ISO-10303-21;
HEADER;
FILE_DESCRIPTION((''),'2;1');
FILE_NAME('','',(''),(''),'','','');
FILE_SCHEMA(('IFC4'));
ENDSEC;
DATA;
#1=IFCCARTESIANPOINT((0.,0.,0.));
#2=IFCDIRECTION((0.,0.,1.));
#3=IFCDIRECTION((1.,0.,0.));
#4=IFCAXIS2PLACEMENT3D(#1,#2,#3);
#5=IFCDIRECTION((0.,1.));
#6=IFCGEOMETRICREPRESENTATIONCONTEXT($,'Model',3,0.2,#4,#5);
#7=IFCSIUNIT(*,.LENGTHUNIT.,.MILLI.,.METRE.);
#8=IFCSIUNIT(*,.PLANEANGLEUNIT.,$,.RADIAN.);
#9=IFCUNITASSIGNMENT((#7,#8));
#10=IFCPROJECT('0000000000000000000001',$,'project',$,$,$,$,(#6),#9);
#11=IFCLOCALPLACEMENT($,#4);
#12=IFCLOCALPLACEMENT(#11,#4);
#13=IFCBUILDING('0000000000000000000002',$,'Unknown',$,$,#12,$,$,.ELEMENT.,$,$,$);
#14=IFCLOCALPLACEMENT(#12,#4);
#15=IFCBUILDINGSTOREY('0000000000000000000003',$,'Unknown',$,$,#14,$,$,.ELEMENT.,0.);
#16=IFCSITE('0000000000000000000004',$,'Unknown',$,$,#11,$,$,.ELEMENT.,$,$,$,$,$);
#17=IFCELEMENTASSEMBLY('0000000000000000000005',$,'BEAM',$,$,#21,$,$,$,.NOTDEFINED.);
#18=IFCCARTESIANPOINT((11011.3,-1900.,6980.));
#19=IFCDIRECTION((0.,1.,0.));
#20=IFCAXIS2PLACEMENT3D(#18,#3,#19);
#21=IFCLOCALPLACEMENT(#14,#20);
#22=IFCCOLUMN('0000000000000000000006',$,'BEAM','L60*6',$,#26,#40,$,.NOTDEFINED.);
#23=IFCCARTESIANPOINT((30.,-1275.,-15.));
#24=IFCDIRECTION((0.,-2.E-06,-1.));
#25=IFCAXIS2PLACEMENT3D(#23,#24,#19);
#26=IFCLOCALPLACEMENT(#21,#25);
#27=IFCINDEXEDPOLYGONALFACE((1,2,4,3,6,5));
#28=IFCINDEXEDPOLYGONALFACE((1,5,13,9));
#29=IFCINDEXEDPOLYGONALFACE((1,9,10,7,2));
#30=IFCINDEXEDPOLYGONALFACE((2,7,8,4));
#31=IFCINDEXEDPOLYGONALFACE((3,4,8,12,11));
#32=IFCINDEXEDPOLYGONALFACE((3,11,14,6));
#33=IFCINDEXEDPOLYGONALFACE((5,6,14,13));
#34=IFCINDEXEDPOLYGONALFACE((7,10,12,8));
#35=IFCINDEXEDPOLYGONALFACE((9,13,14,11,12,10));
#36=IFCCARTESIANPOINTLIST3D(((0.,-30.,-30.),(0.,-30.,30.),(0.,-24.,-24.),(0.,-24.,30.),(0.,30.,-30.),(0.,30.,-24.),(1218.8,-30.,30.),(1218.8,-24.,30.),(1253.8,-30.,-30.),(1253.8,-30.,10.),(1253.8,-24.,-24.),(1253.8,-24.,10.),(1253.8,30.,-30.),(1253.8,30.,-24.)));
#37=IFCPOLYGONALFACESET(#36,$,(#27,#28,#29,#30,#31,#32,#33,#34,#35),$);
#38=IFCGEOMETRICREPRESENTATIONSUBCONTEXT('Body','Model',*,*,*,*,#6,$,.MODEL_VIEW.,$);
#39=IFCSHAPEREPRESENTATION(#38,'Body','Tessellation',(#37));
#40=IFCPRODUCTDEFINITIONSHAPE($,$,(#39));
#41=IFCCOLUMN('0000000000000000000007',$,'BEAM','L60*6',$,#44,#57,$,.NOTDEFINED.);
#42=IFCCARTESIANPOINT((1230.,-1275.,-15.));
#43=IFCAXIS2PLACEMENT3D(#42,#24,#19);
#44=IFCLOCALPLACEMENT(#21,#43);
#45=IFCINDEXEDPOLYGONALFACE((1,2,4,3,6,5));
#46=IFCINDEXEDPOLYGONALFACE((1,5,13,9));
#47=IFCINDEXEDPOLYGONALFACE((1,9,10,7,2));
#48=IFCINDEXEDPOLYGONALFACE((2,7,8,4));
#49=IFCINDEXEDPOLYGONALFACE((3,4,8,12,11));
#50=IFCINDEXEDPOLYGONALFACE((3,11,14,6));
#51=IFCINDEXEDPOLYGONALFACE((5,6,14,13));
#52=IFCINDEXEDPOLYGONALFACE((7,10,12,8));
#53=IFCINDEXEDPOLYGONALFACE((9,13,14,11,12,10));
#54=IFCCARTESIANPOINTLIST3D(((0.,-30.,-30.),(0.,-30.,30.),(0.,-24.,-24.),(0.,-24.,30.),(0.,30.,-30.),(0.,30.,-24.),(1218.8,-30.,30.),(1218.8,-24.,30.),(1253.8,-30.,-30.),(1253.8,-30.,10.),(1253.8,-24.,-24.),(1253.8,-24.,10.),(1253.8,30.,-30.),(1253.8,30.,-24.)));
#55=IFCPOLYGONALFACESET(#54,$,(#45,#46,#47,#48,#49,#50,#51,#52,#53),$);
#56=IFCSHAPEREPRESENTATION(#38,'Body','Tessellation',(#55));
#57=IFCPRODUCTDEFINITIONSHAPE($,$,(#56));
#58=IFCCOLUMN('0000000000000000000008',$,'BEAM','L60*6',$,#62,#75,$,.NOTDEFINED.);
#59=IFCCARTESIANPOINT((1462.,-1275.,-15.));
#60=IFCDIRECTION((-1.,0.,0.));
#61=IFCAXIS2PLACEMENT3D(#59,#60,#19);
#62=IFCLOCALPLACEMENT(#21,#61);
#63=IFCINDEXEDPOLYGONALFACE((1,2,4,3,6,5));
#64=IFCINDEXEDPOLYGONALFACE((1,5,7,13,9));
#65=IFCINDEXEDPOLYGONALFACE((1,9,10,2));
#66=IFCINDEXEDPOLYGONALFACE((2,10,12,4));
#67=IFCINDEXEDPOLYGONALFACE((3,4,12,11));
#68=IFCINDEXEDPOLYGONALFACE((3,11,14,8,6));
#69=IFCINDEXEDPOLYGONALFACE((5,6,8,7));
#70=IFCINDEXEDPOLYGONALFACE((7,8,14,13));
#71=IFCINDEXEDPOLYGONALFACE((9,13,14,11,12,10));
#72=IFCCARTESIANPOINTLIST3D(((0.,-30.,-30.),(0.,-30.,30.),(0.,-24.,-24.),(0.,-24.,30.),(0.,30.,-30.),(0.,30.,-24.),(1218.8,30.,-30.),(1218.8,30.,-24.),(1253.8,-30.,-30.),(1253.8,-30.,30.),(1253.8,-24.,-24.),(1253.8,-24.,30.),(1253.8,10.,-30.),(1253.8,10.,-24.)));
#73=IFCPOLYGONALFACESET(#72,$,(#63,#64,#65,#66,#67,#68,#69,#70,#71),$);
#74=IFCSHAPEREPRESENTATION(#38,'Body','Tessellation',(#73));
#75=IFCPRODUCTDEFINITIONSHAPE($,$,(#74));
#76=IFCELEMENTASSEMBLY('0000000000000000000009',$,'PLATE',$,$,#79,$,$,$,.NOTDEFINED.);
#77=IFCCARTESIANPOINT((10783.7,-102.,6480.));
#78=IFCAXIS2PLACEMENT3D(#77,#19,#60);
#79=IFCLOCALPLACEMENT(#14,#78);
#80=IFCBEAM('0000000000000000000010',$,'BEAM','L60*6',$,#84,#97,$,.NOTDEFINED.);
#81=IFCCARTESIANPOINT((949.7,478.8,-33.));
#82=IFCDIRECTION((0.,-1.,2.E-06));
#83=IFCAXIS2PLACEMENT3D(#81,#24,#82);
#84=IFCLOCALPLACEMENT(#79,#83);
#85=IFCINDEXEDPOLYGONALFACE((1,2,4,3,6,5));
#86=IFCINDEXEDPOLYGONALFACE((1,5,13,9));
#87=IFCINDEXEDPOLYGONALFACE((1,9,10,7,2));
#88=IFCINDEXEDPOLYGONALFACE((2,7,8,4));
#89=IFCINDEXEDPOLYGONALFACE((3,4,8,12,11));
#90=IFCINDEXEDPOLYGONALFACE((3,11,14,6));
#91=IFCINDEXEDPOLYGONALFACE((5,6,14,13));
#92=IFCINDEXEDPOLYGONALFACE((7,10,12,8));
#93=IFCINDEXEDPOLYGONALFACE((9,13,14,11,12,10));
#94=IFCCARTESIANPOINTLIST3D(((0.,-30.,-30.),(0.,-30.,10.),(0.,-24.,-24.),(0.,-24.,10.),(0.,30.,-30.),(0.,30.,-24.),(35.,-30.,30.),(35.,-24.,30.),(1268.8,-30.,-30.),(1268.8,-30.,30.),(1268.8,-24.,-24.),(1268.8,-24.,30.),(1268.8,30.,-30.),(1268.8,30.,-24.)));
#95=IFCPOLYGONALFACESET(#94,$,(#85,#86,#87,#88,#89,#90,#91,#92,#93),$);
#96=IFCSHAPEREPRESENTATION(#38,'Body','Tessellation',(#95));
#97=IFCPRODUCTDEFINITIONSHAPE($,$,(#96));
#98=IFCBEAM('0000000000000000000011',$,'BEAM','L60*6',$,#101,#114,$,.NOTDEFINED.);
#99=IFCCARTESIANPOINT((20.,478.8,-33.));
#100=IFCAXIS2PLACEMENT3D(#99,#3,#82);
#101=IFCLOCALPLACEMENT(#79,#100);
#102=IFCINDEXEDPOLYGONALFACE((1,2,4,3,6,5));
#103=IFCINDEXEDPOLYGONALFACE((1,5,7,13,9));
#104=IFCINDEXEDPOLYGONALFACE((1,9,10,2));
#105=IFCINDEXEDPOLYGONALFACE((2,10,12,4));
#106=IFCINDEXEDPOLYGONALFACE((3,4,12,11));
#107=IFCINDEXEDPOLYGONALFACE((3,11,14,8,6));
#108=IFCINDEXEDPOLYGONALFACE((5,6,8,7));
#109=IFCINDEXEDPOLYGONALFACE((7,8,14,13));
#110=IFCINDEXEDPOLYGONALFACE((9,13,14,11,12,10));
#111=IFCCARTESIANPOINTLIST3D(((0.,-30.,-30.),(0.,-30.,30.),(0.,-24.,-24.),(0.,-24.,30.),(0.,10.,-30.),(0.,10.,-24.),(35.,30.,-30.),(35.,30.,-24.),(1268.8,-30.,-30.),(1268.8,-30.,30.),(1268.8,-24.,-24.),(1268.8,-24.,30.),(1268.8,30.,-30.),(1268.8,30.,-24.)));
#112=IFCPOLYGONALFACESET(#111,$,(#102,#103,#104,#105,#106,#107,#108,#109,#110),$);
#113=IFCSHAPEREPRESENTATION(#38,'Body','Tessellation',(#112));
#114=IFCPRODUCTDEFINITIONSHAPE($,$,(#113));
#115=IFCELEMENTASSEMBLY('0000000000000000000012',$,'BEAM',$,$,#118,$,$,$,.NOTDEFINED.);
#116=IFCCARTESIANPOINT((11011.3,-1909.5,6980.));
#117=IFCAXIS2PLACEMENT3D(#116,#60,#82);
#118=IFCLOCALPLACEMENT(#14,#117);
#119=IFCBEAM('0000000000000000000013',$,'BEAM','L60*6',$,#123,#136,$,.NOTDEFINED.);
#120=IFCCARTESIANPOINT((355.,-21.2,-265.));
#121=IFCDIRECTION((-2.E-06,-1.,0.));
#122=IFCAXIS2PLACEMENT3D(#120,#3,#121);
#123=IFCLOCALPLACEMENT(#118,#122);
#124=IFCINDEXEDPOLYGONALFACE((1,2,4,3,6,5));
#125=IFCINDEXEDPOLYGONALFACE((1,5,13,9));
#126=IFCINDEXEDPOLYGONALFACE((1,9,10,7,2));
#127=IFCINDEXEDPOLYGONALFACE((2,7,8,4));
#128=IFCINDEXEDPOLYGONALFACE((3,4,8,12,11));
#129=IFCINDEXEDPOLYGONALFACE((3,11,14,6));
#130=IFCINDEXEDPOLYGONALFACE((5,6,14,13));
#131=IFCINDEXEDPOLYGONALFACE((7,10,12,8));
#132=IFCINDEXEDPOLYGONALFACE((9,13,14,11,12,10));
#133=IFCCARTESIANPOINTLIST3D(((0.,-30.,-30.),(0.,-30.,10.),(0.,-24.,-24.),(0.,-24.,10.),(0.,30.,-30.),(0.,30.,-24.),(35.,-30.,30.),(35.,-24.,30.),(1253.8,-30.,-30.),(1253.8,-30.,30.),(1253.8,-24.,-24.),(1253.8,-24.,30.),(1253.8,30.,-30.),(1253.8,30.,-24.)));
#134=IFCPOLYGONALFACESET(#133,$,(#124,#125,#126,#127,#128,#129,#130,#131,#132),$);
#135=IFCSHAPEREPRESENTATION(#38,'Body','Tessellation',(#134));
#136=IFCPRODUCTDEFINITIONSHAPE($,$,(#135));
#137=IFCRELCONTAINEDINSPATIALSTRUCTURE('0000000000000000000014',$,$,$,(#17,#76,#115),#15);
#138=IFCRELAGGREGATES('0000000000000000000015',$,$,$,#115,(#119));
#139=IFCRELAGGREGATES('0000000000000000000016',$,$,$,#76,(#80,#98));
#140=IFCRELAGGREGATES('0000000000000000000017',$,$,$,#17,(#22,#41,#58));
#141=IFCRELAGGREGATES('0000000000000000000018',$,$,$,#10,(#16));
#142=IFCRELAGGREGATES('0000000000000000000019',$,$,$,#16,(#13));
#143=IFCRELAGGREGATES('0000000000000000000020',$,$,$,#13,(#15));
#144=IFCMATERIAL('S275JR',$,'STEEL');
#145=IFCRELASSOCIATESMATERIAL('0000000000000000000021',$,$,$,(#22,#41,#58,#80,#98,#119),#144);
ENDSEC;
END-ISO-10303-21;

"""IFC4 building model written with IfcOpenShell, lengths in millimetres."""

from ifc_helpers import new_model, si_unit, direction, frame, origin_with_axes, place, context, subcontext, project, spatial, line, indexed_curve, outline, extrude, material, element, aggregate, save


model = new_model("IFC4")

# Units and contexts
model_context = context("Model", 3, precision=0.2, world=origin_with_axes(), true_north=direction((0.0, 1.0)))
body_context = subcontext(model_context, "Body", "Model", "MODEL_VIEW")
ifc_project = project(units=[si_unit("LENGTHUNIT", "METRE", prefix="MILLI"), si_unit("PLANEANGLEUNIT", "RADIAN")], contexts=[model_context])

# Site, building, storey
site_placement = place(None, origin_with_axes())
site = spatial("IfcSite", under=ifc_project, at=site_placement, Name="Unknown", CompositionType="ELEMENT")
building_placement = place(site_placement, origin_with_axes())
building = spatial("IfcBuilding", under=site, at=building_placement, Name="Unknown", CompositionType="ELEMENT")
storey_placement = place(building_placement, origin_with_axes())
storey = spatial("IfcBuildingStorey", under=building, at=storey_placement, Name="Unknown", CompositionType="ELEMENT", Elevation=0.0)

# Shared definitions
ifc_material_1 = material(Name="S275JR", Category="STEEL")

# Element assembly, columns, voiding features
assembly_1_placement = place(storey_placement, frame((11011.3, -1900.0, 6980.0), z_axis=(1.0, 0.0, 0.0), x_axis=(0.0, 1.0, 0.0)))
assembly_1 = element("IfcElementAssembly", 1, at=assembly_1_placement, inside=storey, Name="BEAM", PredefinedType="NOTDEFINED")
column_1_placement = place(assembly_1_placement, frame((30.0, -1275.0, -15.0), z_axis=(0.0, -0.000002, -1.0), x_axis=(0.0, 1.0, 0.0)))
column_1 = element("IfcColumn", 2, at=column_1_placement, material=ifc_material_1, Name="BEAM", Description="L60*6", PredefinedType="NOTDEFINED", context=body_context, shape_type="SolidModel", body=[
    extrude(outline(indexed_curve([(-30.0, -30.0), (30.0, -30.0), (30.0, -24.0), (-24.0, -24.0), (-24.0, 30.0), (-30.0, 30.0)], segments=[line(1, 2, 3, 4, 5, 6, 1)])), frame((0.0, 0.0, 0.0), z_axis=(-1.0, 0.0, 0.0), x_axis=(0.0, 0.0, 1.0)), (0.0, -0.000002, -1.0), 1253.8),
])
voiding_feature_1_placement = place(column_1_placement, frame((1253.8, 0.0, 10.0), z_axis=(0.0, -1.0, 0.000002), x_axis=(0.0, 0.0, 1.0)))
element("IfcVoidingFeature", 3, at=voiding_feature_1_placement, cuts=column_1, Name="CUTPART", PredefinedType="HOLE", context=body_context, shape_type="SolidModel", body=[
    extrude(outline(indexed_curve([(0.0, 0.0), (20.0, 0.0), (20.0, 35.0)], segments=[line(1, 2, 3, 1)])), frame((0.0, 0.0, 33.0), z_axis=(0.0, 0.0, 1.0), x_axis=(1.0, 0.0, 0.0)), (0.0, -0.000002, -1.0), 66.0),
])
column_2_placement = place(assembly_1_placement, frame((1230.0, -1275.0, -15.0), z_axis=(0.0, -0.000002, -1.0), x_axis=(0.0, 1.0, 0.0)))
column_2 = element("IfcColumn", 4, at=column_2_placement, material=ifc_material_1, Name="BEAM", Description="L60*6", PredefinedType="NOTDEFINED", context=body_context, shape_type="SolidModel", body=[
    extrude(outline(indexed_curve([(-30.0, -30.0), (30.0, -30.0), (30.0, -24.0), (-24.0, -24.0), (-24.0, 30.0), (-30.0, 30.0)], segments=[line(1, 2, 3, 4, 5, 6, 1)])), frame((0.0, 0.0, 0.0), z_axis=(-1.0, 0.0, 0.0), x_axis=(0.0, 0.0, 1.0)), (0.0, -0.000002, -1.0), 1253.8),
])
voiding_feature_2_placement = place(column_2_placement, frame((1253.8, 0.0, 10.0), z_axis=(0.0, -1.0, 0.000002), x_axis=(0.0, 0.0, 1.0)))
element("IfcVoidingFeature", 5, at=voiding_feature_2_placement, cuts=column_2, Name="CUTPART", PredefinedType="HOLE", context=body_context, shape_type="SolidModel", body=[
    extrude(outline(indexed_curve([(0.0, 0.0), (20.0, 0.0), (20.0, 35.0)], segments=[line(1, 2, 3, 1)])), frame((0.0, 0.0, 33.0), z_axis=(0.0, 0.0, 1.0), x_axis=(1.0, 0.0, 0.0)), (0.0, -0.000002, -1.0), 66.0),
])
column_3_placement = place(assembly_1_placement, frame((1462.0, -1275.0, -15.0), z_axis=(-1.0, 0.0, 0.0), x_axis=(0.0, 1.0, 0.0)))
column_3 = element("IfcColumn", 6, at=column_3_placement, material=ifc_material_1, Name="BEAM", Description="L60*6", PredefinedType="NOTDEFINED", context=body_context, shape_type="SolidModel", body=[
    extrude(outline(indexed_curve([(-30.0, -30.0), (30.0, -30.0), (30.0, -24.0), (-24.0, -24.0), (-24.0, 30.0), (-30.0, 30.0)], segments=[line(1, 2, 3, 4, 5, 6, 1)])), frame((0.0, 0.0, 0.0), z_axis=(-1.0, 0.0, 0.0), x_axis=(0.0, 0.0, 1.0)), (0.0, -0.000002, -1.0), 1253.8),
])
voiding_feature_3_placement = place(column_3_placement, frame((1253.8, 10.0, 0.0), z_axis=(0.0, 0.0, 1.0), x_axis=(0.0, 1.0, 0.0)))
element("IfcVoidingFeature", 7, at=voiding_feature_3_placement, cuts=column_3, Name="CUTPART", PredefinedType="HOLE", context=body_context, shape_type="SolidModel", body=[
    extrude(outline(indexed_curve([(0.0, 0.0), (20.0, 0.0), (20.0, 35.0)], segments=[line(1, 2, 3, 1)])), frame((0.0, 0.0, 33.0), z_axis=(0.0, 0.0, 1.0), x_axis=(1.0, 0.0, 0.0)), (0.0, -0.000002, -1.0), 66.0),
])

# Element assembly, beams, voiding features
assembly_2_placement = place(storey_placement, frame((10783.7, -102.0, 6480.0), z_axis=(0.0, 1.0, 0.0), x_axis=(-1.0, 0.0, 0.0)))
assembly_2 = element("IfcElementAssembly", 8, at=assembly_2_placement, inside=storey, Name="PLATE", PredefinedType="NOTDEFINED")
beam_1_placement = place(assembly_2_placement, frame((949.7, 478.8, -33.0), z_axis=(0.0, -0.000002, -1.0), x_axis=(0.0, -1.0, 0.000002)))
beam_1 = element("IfcBeam", 9, at=beam_1_placement, material=ifc_material_1, Name="BEAM", Description="L60*6", PredefinedType="NOTDEFINED", context=body_context, shape_type="SolidModel", body=[
    extrude(outline(indexed_curve([(-30.0, -30.0), (30.0, -30.0), (30.0, -24.0), (-24.0, -24.0), (-24.0, 30.0), (-30.0, 30.0)], segments=[line(1, 2, 3, 4, 5, 6, 1)])), frame((0.0, 0.0, 0.0), z_axis=(-1.0, 0.0, 0.0), x_axis=(0.0, 0.0, 1.0)), (0.0, -0.000002, -1.0), 1268.8),
])
voiding_feature_4_placement = place(beam_1_placement, frame((0.0, 0.0, 10.0), z_axis=(0.0, 1.0, 0.0), x_axis=(0.0, 0.0, 1.0)))
element("IfcVoidingFeature", 10, at=voiding_feature_4_placement, cuts=beam_1, Name="CUTPART", PredefinedType="HOLE", context=body_context, shape_type="SolidModel", body=[
    extrude(outline(indexed_curve([(0.0, 0.0), (20.0, 0.0), (20.0, 35.0)], segments=[line(1, 2, 3, 1)])), frame((0.0, 0.0, 33.0), z_axis=(0.0, 0.0, 1.0), x_axis=(1.0, 0.0, 0.0)), (0.0, -0.000002, -1.0), 66.0),
])
beam_2_placement = place(assembly_2_placement, frame((20.0, 478.8, -33.0), z_axis=(1.0, 0.0, 0.0), x_axis=(0.0, -1.0, 0.000002)))
beam_2 = element("IfcBeam", 11, at=beam_2_placement, material=ifc_material_1, Name="BEAM", Description="L60*6", PredefinedType="NOTDEFINED", context=body_context, shape_type="SolidModel", body=[
    extrude(outline(indexed_curve([(-30.0, -30.0), (30.0, -30.0), (30.0, -24.0), (-24.0, -24.0), (-24.0, 30.0), (-30.0, 30.0)], segments=[line(1, 2, 3, 4, 5, 6, 1)])), frame((0.0, 0.0, 0.0), z_axis=(-1.0, 0.0, 0.0), x_axis=(0.0, 0.0, 1.0)), (0.0, -0.000002, -1.0), 1268.8),
])
voiding_feature_5_placement = place(beam_2_placement, frame((0.0, 10.0, 0.0), z_axis=(0.0, -0.000002, -1.0), x_axis=(0.0, 1.0, 0.0)))
element("IfcVoidingFeature", 12, at=voiding_feature_5_placement, cuts=beam_2, Name="CUTPART", PredefinedType="HOLE", context=body_context, shape_type="SolidModel", body=[
    extrude(outline(indexed_curve([(0.0, 0.0), (20.0, 0.0), (20.0, 35.0)], segments=[line(1, 2, 3, 1)])), frame((0.0, 0.0, 33.0), z_axis=(0.0, 0.0, 1.0), x_axis=(1.0, 0.0, 0.0)), (0.0, -0.000002, -1.0), 66.0),
])

# Element assembly, beam, voiding feature
assembly_3_placement = place(storey_placement, frame((11011.3, -1909.5, 6980.0), z_axis=(-1.0, 0.0, 0.0), x_axis=(0.0, -1.0, 0.000002)))
assembly_3 = element("IfcElementAssembly", 13, at=assembly_3_placement, inside=storey, Name="BEAM", PredefinedType="NOTDEFINED")
beam_3_placement = place(assembly_3_placement, frame((355.0, -21.2, -265.0), z_axis=(1.0, 0.0, 0.0), x_axis=(-0.000002, -1.0, 0.0)))
beam_3 = element("IfcBeam", 14, at=beam_3_placement, material=ifc_material_1, Name="BEAM", Description="L60*6", PredefinedType="NOTDEFINED", context=body_context, shape_type="SolidModel", body=[
    extrude(outline(indexed_curve([(-30.0, -30.0), (30.0, -30.0), (30.0, -24.0), (-24.0, -24.0), (-24.0, 30.0), (-30.0, 30.0)], segments=[line(1, 2, 3, 4, 5, 6, 1)])), frame((0.0, 0.0, 0.0), z_axis=(-1.0, 0.0, 0.0), x_axis=(0.0, 0.0, 1.0)), (0.0, -0.000002, -1.0), 1253.8),
])
voiding_feature_6_placement = place(beam_3_placement, frame((0.0, 0.0, 10.0), z_axis=(0.0, 1.0, 0.0), x_axis=(0.0, 0.0, 1.0)))
element("IfcVoidingFeature", 15, at=voiding_feature_6_placement, cuts=beam_3, Name="CUTPART", PredefinedType="HOLE", context=body_context, shape_type="SolidModel", body=[
    extrude(outline(indexed_curve([(0.0, 0.0), (20.0, 0.0), (20.0, 35.0)], segments=[line(1, 2, 3, 1)])), frame((0.0, 0.0, 33.0), z_axis=(0.0, 0.0, 1.0), x_axis=(1.0, 0.0, 0.0)), (0.0, -0.000002, -1.0), 66.0),
])

aggregate(assembly_3, [beam_3])
aggregate(assembly_2, [beam_1, beam_2])
aggregate(assembly_1, [column_1, column_2, column_3])

save(model, "model.ifc")
